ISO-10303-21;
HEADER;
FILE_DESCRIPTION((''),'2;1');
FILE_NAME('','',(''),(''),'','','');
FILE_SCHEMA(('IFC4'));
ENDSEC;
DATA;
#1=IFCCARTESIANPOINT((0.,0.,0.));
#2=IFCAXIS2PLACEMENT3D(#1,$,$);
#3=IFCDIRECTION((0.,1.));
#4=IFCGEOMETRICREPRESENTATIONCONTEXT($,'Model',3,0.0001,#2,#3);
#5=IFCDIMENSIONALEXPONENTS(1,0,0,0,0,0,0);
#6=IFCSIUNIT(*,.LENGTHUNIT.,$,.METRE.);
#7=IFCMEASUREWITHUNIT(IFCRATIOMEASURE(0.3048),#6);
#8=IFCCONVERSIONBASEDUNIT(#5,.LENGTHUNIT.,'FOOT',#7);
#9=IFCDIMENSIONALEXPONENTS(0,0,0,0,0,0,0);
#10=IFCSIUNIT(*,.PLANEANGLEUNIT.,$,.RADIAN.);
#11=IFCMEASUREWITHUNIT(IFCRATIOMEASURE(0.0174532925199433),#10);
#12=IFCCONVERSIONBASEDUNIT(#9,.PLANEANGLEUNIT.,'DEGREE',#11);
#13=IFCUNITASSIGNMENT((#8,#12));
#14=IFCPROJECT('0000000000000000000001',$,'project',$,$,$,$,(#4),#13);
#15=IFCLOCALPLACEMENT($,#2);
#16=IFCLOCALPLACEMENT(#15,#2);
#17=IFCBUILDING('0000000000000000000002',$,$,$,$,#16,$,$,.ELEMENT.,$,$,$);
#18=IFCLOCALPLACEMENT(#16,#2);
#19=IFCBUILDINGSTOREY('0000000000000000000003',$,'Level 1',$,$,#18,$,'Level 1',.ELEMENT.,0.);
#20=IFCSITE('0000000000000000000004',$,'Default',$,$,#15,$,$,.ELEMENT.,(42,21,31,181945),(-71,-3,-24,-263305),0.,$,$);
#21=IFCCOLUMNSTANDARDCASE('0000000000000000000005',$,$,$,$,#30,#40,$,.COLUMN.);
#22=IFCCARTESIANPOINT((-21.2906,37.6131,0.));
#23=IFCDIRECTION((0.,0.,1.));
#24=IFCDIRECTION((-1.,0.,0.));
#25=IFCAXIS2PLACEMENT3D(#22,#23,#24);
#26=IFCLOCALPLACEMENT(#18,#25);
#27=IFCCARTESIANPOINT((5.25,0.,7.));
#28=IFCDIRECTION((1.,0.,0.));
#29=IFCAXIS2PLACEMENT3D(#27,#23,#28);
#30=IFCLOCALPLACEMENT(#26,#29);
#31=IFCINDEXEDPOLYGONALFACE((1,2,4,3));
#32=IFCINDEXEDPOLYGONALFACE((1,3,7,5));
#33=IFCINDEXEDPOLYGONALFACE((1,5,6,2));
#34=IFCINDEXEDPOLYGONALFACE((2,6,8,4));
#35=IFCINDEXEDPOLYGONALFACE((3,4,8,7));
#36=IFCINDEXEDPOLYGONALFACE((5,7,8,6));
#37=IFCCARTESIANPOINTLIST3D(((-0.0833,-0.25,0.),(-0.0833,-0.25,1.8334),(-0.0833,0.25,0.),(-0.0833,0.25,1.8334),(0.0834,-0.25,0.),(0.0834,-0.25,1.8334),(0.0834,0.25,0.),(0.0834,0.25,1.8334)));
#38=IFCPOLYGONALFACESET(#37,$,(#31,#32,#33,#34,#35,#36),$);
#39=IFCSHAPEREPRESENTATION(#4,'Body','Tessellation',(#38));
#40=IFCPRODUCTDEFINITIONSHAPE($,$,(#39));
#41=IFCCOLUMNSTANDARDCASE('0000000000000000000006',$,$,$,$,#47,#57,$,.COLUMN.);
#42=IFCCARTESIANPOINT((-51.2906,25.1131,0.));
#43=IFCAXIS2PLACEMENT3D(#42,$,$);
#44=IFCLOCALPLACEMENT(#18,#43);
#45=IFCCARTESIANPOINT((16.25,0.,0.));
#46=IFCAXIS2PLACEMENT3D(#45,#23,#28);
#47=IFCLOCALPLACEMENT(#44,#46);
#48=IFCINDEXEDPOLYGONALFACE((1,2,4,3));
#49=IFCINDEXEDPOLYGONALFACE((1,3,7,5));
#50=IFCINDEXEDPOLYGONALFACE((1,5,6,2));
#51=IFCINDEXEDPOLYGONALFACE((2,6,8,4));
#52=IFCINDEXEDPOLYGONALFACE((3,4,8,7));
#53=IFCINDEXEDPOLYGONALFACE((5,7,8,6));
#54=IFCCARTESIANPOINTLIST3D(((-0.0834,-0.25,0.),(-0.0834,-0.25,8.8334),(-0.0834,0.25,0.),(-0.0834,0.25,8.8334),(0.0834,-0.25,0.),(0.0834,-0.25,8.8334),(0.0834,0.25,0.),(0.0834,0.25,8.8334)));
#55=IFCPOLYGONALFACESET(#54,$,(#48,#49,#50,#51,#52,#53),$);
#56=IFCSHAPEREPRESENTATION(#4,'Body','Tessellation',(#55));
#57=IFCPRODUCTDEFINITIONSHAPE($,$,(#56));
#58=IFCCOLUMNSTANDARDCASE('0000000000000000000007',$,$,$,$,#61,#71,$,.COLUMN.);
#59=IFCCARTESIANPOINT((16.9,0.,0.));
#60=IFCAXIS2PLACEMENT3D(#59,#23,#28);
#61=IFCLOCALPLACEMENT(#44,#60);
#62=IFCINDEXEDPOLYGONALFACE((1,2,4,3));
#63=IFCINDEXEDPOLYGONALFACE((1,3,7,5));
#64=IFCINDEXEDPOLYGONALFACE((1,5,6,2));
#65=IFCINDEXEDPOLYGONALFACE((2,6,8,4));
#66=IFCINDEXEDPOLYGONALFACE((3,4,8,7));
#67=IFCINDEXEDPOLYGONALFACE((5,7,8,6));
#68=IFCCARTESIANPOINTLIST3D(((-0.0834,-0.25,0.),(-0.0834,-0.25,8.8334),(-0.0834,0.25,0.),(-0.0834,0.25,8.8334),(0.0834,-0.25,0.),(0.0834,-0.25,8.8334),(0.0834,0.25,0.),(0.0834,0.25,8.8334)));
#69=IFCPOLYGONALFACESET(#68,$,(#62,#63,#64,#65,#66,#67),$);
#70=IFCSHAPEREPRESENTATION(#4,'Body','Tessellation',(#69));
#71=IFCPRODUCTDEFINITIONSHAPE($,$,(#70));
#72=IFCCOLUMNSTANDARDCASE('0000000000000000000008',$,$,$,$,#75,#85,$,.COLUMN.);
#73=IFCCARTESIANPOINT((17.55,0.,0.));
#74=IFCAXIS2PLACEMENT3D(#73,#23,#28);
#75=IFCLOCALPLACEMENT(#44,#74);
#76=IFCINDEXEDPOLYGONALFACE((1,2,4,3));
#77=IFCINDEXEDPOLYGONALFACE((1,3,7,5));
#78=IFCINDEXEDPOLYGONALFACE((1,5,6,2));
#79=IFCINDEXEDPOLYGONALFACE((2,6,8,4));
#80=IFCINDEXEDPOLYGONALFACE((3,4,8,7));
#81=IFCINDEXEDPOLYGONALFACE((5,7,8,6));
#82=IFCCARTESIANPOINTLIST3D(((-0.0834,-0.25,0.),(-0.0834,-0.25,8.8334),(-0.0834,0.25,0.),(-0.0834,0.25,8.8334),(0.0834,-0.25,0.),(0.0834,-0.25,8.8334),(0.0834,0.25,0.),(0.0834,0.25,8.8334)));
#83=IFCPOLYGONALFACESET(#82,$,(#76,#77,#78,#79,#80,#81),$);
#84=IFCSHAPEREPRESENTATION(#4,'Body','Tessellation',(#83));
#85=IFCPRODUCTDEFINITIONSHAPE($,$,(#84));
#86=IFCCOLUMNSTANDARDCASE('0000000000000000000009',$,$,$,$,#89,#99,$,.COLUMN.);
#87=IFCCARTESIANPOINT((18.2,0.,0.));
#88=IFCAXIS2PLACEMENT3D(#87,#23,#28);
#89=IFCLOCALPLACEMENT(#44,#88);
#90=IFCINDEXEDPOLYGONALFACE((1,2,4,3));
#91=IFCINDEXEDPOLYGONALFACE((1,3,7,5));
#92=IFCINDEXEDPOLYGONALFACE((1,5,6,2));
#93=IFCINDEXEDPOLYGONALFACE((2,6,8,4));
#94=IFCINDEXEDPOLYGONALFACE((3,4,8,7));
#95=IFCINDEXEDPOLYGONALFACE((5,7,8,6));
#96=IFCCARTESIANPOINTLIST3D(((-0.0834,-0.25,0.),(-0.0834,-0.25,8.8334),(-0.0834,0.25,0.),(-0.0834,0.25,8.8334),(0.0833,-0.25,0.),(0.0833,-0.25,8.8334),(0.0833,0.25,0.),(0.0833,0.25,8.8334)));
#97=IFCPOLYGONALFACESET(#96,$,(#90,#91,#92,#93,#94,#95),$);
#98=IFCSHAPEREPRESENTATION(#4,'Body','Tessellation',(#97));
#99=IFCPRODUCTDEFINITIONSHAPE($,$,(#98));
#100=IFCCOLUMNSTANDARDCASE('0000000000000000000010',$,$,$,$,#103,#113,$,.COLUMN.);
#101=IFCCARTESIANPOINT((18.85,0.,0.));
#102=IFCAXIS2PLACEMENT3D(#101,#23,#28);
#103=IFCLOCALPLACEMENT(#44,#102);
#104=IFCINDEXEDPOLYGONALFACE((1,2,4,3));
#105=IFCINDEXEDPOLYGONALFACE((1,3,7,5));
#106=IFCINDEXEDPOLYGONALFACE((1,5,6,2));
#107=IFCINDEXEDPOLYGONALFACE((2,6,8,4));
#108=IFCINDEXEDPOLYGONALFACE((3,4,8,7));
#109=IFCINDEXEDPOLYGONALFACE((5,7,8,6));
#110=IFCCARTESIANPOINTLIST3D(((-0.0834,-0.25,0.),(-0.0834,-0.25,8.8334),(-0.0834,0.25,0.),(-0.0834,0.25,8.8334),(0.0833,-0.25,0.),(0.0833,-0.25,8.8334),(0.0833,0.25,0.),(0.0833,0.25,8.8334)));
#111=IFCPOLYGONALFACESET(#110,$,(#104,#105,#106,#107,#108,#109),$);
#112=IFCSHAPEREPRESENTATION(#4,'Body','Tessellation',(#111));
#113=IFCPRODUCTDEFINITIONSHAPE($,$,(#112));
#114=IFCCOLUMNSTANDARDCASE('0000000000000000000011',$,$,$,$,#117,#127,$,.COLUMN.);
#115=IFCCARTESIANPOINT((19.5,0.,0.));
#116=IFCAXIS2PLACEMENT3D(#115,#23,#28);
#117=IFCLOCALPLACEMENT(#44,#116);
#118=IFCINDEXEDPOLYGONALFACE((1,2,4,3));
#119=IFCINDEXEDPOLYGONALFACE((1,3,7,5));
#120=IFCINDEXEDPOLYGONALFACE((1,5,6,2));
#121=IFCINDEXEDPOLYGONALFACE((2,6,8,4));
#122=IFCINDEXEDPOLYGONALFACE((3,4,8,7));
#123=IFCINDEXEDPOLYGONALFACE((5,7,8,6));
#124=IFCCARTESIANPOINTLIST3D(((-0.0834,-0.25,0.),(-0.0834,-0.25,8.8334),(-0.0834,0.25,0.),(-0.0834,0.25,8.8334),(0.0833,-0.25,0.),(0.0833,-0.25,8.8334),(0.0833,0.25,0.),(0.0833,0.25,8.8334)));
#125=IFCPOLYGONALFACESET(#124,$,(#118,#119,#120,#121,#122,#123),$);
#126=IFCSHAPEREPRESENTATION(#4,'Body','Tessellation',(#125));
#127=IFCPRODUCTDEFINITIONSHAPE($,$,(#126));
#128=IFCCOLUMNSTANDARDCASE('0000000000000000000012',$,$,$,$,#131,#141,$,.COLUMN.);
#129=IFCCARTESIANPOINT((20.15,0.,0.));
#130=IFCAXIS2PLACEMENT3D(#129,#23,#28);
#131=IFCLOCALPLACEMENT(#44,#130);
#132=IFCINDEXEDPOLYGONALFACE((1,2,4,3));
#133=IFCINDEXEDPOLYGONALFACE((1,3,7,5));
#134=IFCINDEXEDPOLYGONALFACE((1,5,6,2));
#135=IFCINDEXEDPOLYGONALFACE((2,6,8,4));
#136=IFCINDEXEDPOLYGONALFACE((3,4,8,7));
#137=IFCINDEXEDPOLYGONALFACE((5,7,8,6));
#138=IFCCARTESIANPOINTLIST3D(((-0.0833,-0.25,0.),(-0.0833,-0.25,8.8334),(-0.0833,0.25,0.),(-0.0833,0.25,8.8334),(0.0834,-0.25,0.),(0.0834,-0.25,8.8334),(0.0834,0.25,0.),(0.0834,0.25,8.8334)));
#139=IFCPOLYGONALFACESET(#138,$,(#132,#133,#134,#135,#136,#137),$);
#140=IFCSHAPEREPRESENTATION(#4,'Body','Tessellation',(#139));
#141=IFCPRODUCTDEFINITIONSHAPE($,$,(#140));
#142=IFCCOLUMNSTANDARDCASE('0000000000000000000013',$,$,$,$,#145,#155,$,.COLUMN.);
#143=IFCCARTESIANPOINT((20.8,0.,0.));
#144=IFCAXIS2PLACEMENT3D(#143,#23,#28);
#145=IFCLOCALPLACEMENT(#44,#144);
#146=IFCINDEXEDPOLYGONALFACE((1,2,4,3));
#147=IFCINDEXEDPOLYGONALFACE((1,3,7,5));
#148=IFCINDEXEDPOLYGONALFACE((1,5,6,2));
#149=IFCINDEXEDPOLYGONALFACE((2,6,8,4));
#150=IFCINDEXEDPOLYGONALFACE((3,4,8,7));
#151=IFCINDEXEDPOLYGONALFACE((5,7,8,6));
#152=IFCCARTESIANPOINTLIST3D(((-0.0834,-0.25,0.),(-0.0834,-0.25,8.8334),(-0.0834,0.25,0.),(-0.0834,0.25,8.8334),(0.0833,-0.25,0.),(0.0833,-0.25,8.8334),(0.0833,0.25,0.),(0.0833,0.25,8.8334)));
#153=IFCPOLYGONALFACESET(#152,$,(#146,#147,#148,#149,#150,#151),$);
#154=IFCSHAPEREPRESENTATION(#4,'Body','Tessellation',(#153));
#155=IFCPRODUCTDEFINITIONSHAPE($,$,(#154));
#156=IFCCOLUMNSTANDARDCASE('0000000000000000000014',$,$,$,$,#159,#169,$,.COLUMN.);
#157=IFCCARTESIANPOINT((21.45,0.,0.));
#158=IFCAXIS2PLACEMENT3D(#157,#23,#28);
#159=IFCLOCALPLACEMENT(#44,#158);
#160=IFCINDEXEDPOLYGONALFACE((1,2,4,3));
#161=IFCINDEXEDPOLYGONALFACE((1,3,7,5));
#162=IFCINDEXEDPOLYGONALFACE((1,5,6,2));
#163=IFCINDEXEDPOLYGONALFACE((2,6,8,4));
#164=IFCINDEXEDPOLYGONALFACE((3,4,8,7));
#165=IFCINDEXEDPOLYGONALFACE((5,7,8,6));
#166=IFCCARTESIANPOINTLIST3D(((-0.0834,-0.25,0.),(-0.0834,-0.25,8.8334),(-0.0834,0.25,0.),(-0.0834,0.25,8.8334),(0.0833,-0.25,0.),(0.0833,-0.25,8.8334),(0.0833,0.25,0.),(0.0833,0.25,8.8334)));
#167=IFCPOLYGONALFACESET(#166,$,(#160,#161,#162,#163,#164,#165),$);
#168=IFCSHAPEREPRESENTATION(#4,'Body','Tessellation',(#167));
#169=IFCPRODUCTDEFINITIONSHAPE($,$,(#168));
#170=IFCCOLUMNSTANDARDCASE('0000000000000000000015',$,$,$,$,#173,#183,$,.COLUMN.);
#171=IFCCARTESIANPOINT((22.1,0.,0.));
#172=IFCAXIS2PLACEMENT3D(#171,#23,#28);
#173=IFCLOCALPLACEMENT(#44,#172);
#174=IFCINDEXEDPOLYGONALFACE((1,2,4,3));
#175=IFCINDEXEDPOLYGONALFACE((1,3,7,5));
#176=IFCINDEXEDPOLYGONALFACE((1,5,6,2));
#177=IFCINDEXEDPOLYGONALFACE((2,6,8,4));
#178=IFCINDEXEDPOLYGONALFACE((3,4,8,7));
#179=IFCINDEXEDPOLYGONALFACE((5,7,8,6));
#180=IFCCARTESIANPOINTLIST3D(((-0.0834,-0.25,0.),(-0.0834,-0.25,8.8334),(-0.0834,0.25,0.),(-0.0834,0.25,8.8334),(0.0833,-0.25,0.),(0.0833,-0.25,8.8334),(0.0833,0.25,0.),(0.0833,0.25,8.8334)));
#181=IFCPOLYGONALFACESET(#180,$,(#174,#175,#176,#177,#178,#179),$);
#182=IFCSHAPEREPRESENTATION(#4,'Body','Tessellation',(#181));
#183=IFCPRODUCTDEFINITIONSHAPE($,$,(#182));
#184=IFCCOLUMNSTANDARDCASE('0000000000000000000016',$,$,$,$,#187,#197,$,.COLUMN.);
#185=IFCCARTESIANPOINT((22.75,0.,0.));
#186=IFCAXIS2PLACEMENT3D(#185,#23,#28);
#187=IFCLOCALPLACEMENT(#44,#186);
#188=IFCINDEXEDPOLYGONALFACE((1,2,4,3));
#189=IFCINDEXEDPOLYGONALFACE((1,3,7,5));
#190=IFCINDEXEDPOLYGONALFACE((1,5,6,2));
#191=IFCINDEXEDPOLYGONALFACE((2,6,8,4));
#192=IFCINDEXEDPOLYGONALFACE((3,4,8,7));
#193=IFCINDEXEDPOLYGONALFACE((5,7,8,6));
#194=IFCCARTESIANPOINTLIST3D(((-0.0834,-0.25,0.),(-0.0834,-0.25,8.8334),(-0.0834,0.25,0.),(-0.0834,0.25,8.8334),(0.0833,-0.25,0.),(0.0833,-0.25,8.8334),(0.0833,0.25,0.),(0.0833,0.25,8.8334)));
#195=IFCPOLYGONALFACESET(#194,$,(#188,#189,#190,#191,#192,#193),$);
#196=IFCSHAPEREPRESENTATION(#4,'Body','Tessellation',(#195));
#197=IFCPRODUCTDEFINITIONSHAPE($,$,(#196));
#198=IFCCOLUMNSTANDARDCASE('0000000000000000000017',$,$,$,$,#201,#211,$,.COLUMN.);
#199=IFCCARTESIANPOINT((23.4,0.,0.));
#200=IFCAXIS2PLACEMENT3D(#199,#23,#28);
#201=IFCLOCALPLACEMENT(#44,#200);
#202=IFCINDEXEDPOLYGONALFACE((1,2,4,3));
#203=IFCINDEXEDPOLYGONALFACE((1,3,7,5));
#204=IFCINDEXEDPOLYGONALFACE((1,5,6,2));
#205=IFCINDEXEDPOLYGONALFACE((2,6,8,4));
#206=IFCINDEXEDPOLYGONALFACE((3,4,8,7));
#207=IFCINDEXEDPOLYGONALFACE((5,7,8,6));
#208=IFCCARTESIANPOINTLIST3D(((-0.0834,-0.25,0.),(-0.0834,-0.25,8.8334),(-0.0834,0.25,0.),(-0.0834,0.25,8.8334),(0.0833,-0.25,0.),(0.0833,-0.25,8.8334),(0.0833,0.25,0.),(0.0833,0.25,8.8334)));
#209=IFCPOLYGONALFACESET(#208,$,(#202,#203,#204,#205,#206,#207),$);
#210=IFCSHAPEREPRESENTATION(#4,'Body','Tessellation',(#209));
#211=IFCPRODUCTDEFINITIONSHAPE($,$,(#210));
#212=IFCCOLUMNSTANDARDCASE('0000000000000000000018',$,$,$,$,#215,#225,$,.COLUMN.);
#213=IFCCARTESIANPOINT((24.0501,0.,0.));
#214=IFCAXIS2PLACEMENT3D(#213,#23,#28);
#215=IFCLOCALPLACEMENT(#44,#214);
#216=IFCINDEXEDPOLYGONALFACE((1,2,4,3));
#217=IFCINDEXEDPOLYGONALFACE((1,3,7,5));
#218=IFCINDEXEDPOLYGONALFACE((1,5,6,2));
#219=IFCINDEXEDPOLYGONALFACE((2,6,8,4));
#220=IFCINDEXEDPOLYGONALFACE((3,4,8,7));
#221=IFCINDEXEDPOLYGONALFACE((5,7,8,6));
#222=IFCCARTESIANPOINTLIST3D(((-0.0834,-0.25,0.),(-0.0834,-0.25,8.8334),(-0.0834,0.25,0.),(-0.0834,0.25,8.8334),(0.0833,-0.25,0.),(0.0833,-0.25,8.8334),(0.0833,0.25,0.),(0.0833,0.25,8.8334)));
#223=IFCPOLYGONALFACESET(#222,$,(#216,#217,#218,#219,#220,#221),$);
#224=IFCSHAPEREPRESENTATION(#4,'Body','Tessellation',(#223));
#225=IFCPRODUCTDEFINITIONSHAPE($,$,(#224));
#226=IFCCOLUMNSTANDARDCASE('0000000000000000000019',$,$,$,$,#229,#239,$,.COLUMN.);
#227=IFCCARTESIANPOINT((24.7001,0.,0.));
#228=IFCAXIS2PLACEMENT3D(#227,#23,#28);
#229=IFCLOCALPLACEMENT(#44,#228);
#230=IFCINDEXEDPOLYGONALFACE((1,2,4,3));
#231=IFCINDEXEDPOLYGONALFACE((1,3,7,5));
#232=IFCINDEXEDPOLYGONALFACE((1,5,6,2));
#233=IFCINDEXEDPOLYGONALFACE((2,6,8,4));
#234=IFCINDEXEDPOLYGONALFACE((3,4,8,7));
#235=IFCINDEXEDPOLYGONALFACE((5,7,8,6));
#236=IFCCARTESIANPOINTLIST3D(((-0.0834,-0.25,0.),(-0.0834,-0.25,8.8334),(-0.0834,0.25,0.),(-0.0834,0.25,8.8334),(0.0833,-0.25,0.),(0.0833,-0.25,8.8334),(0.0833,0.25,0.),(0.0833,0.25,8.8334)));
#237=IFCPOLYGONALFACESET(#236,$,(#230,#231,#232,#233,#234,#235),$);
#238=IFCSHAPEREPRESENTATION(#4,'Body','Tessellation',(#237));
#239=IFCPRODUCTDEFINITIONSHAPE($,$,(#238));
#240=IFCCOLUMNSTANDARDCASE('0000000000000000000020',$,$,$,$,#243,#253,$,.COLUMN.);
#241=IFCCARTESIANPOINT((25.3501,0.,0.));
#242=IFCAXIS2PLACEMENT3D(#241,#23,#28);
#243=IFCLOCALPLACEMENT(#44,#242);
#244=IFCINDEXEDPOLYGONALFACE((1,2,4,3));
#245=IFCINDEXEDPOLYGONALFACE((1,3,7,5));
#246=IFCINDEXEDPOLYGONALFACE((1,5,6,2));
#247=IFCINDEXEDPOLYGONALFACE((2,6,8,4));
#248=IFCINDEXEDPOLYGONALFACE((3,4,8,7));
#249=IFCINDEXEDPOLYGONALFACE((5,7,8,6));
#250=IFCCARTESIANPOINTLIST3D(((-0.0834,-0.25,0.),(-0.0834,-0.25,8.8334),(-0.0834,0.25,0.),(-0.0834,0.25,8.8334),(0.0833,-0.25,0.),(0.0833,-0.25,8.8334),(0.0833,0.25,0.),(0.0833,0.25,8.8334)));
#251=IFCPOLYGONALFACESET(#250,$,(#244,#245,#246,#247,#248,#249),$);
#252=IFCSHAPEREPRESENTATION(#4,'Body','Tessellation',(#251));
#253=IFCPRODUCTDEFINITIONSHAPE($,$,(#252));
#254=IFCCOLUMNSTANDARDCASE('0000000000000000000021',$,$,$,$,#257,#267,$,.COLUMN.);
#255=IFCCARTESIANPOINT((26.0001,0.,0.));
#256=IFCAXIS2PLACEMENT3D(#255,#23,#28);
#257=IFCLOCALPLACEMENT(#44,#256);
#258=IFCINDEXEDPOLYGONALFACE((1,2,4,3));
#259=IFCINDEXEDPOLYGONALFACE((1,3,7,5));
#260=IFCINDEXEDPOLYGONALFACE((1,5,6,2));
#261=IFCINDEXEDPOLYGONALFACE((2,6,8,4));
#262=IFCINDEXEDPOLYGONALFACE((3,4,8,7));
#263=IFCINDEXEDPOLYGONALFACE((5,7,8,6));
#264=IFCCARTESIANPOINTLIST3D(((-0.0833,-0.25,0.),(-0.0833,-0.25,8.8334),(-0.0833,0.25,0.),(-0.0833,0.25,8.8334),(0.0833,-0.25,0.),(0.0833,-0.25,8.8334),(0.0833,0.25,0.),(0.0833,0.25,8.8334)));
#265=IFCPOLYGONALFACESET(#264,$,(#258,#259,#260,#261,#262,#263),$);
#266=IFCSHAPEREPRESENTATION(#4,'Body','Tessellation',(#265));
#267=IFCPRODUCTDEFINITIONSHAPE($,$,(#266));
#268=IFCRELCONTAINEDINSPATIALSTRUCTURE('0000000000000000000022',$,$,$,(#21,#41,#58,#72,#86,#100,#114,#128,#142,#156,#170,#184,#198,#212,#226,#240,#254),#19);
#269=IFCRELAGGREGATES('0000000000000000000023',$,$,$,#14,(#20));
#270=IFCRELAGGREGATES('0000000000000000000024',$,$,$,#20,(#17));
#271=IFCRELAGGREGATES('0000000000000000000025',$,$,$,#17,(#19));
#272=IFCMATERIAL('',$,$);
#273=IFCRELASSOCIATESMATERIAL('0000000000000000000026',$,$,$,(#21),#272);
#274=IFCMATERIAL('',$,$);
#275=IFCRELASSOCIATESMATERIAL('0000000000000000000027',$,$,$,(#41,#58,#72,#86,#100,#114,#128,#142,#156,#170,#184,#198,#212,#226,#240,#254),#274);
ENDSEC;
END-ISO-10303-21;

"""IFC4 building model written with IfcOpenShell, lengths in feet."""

from ifc_helpers import new_model, entity, si_unit, converted_unit, direction, frame, origin, place, context, project, spatial, rectangle, extrude, material, element, save


model = new_model("IFC4")

# Units and contexts
model_context = context("Model", 3, precision=0.0001, world=origin(), true_north=direction((0.0, 1.0)))
ifc_project = project(units=[converted_unit("LENGTHUNIT", "FOOT", entity("IfcRatioMeasure", 0.3048), si_unit("LENGTHUNIT", "METRE"), dimensions=[1, 0, 0, 0, 0, 0, 0]), converted_unit("PLANEANGLEUNIT", "DEGREE", entity("IfcRatioMeasure", 0.0174532925199433), si_unit("PLANEANGLEUNIT", "RADIAN"), dimensions=[0, 0, 0, 0, 0, 0, 0])], contexts=[model_context])

# Site, building, storey
site_placement = place(None, origin())
site = spatial("IfcSite", under=ifc_project, at=site_placement, Name="Default", CompositionType="ELEMENT", RefLatitude=(42, 21, 31, 181945), RefLongitude=(-71, -3, -24, -263305), RefElevation=0.0)
building_placement = place(site_placement, origin())
building = spatial("IfcBuilding", under=site, at=building_placement, CompositionType="ELEMENT")
storey_placement = place(building_placement, origin())
storey = spatial("IfcBuildingStorey", under=building, at=storey_placement, Name="Level 1", LongName="Level 1", CompositionType="ELEMENT", Elevation=0.0)

# Columns
placement_1 = place(storey_placement, frame((-21.2906, 37.6131, 0.0), z_axis=(0.0, 0.0, 1.0), x_axis=(-1.0, 0.0, 0.0)))
ifc_material_1 = material(Name="")
for number, where, z_axis, x_axis in (
    (1, (5.25, 0.0, 7.0), (0.0, 0.0, 1.0), (1.0, 0.0, 0.0)),
):
    element("IfcColumnStandardCase", number, at=place(placement_1, frame(where, z_axis=z_axis, x_axis=x_axis)), inside=storey, material=ifc_material_1, PredefinedType="COLUMN", context=model_context, shape_type="SweptSolid", body=[
        extrude(rectangle(XDim=0.1667, YDim=0.5), origin(), (0.0, 0.0, 1.0), 1.8334),
    ])
ifc_material_2 = material(Name="")
placement_2 = place(storey_placement, frame((-51.2906, 25.1131, 0.0)))
for number, where, z_axis, x_axis in (
    (2, (16.25, 0.0, 0.0), (0.0, 0.0, 1.0), (1.0, 0.0, 0.0)),
    (3, (16.9, 0.0, 0.0), (0.0, 0.0, 1.0), (1.0, 0.0, 0.0)),
    (4, (17.55, 0.0, 0.0), (0.0, 0.0, 1.0), (1.0, 0.0, 0.0)),
    (5, (18.2, 0.0, 0.0), (0.0, 0.0, 1.0), (1.0, 0.0, 0.0)),
    (6, (18.85, 0.0, 0.0), (0.0, 0.0, 1.0), (1.0, 0.0, 0.0)),
    (7, (19.5, 0.0, 0.0), (0.0, 0.0, 1.0), (1.0, 0.0, 0.0)),
    (8, (20.15, 0.0, 0.0), (0.0, 0.0, 1.0), (1.0, 0.0, 0.0)),
    (9, (20.8, 0.0, 0.0), (0.0, 0.0, 1.0), (1.0, 0.0, 0.0)),
    (10, (21.45, 0.0, 0.0), (0.0, 0.0, 1.0), (1.0, 0.0, 0.0)),
    (11, (22.1, 0.0, 0.0), (0.0, 0.0, 1.0), (1.0, 0.0, 0.0)),
    (12, (22.75, 0.0, 0.0), (0.0, 0.0, 1.0), (1.0, 0.0, 0.0)),
    (13, (23.4, 0.0, 0.0), (0.0, 0.0, 1.0), (1.0, 0.0, 0.0)),
    (14, (24.0501, 0.0, 0.0), (0.0, 0.0, 1.0), (1.0, 0.0, 0.0)),
    (15, (24.7001, 0.0, 0.0), (0.0, 0.0, 1.0), (1.0, 0.0, 0.0)),
    (16, (25.3501, 0.0, 0.0), (0.0, 0.0, 1.0), (1.0, 0.0, 0.0)),
    (17, (26.0001, 0.0, 0.0), (0.0, 0.0, 1.0), (1.0, 0.0, 0.0)),
):
    element("IfcColumnStandardCase", number, at=place(placement_2, frame(where, z_axis=z_axis, x_axis=x_axis)), inside=storey, material=ifc_material_2, PredefinedType="COLUMN", context=model_context, shape_type="SweptSolid", body=[
        extrude(rectangle(XDim=0.1667, YDim=0.5), origin(), (0.0, 0.0, 1.0), 8.8334),
    ])

save(model, "model.ifc")
